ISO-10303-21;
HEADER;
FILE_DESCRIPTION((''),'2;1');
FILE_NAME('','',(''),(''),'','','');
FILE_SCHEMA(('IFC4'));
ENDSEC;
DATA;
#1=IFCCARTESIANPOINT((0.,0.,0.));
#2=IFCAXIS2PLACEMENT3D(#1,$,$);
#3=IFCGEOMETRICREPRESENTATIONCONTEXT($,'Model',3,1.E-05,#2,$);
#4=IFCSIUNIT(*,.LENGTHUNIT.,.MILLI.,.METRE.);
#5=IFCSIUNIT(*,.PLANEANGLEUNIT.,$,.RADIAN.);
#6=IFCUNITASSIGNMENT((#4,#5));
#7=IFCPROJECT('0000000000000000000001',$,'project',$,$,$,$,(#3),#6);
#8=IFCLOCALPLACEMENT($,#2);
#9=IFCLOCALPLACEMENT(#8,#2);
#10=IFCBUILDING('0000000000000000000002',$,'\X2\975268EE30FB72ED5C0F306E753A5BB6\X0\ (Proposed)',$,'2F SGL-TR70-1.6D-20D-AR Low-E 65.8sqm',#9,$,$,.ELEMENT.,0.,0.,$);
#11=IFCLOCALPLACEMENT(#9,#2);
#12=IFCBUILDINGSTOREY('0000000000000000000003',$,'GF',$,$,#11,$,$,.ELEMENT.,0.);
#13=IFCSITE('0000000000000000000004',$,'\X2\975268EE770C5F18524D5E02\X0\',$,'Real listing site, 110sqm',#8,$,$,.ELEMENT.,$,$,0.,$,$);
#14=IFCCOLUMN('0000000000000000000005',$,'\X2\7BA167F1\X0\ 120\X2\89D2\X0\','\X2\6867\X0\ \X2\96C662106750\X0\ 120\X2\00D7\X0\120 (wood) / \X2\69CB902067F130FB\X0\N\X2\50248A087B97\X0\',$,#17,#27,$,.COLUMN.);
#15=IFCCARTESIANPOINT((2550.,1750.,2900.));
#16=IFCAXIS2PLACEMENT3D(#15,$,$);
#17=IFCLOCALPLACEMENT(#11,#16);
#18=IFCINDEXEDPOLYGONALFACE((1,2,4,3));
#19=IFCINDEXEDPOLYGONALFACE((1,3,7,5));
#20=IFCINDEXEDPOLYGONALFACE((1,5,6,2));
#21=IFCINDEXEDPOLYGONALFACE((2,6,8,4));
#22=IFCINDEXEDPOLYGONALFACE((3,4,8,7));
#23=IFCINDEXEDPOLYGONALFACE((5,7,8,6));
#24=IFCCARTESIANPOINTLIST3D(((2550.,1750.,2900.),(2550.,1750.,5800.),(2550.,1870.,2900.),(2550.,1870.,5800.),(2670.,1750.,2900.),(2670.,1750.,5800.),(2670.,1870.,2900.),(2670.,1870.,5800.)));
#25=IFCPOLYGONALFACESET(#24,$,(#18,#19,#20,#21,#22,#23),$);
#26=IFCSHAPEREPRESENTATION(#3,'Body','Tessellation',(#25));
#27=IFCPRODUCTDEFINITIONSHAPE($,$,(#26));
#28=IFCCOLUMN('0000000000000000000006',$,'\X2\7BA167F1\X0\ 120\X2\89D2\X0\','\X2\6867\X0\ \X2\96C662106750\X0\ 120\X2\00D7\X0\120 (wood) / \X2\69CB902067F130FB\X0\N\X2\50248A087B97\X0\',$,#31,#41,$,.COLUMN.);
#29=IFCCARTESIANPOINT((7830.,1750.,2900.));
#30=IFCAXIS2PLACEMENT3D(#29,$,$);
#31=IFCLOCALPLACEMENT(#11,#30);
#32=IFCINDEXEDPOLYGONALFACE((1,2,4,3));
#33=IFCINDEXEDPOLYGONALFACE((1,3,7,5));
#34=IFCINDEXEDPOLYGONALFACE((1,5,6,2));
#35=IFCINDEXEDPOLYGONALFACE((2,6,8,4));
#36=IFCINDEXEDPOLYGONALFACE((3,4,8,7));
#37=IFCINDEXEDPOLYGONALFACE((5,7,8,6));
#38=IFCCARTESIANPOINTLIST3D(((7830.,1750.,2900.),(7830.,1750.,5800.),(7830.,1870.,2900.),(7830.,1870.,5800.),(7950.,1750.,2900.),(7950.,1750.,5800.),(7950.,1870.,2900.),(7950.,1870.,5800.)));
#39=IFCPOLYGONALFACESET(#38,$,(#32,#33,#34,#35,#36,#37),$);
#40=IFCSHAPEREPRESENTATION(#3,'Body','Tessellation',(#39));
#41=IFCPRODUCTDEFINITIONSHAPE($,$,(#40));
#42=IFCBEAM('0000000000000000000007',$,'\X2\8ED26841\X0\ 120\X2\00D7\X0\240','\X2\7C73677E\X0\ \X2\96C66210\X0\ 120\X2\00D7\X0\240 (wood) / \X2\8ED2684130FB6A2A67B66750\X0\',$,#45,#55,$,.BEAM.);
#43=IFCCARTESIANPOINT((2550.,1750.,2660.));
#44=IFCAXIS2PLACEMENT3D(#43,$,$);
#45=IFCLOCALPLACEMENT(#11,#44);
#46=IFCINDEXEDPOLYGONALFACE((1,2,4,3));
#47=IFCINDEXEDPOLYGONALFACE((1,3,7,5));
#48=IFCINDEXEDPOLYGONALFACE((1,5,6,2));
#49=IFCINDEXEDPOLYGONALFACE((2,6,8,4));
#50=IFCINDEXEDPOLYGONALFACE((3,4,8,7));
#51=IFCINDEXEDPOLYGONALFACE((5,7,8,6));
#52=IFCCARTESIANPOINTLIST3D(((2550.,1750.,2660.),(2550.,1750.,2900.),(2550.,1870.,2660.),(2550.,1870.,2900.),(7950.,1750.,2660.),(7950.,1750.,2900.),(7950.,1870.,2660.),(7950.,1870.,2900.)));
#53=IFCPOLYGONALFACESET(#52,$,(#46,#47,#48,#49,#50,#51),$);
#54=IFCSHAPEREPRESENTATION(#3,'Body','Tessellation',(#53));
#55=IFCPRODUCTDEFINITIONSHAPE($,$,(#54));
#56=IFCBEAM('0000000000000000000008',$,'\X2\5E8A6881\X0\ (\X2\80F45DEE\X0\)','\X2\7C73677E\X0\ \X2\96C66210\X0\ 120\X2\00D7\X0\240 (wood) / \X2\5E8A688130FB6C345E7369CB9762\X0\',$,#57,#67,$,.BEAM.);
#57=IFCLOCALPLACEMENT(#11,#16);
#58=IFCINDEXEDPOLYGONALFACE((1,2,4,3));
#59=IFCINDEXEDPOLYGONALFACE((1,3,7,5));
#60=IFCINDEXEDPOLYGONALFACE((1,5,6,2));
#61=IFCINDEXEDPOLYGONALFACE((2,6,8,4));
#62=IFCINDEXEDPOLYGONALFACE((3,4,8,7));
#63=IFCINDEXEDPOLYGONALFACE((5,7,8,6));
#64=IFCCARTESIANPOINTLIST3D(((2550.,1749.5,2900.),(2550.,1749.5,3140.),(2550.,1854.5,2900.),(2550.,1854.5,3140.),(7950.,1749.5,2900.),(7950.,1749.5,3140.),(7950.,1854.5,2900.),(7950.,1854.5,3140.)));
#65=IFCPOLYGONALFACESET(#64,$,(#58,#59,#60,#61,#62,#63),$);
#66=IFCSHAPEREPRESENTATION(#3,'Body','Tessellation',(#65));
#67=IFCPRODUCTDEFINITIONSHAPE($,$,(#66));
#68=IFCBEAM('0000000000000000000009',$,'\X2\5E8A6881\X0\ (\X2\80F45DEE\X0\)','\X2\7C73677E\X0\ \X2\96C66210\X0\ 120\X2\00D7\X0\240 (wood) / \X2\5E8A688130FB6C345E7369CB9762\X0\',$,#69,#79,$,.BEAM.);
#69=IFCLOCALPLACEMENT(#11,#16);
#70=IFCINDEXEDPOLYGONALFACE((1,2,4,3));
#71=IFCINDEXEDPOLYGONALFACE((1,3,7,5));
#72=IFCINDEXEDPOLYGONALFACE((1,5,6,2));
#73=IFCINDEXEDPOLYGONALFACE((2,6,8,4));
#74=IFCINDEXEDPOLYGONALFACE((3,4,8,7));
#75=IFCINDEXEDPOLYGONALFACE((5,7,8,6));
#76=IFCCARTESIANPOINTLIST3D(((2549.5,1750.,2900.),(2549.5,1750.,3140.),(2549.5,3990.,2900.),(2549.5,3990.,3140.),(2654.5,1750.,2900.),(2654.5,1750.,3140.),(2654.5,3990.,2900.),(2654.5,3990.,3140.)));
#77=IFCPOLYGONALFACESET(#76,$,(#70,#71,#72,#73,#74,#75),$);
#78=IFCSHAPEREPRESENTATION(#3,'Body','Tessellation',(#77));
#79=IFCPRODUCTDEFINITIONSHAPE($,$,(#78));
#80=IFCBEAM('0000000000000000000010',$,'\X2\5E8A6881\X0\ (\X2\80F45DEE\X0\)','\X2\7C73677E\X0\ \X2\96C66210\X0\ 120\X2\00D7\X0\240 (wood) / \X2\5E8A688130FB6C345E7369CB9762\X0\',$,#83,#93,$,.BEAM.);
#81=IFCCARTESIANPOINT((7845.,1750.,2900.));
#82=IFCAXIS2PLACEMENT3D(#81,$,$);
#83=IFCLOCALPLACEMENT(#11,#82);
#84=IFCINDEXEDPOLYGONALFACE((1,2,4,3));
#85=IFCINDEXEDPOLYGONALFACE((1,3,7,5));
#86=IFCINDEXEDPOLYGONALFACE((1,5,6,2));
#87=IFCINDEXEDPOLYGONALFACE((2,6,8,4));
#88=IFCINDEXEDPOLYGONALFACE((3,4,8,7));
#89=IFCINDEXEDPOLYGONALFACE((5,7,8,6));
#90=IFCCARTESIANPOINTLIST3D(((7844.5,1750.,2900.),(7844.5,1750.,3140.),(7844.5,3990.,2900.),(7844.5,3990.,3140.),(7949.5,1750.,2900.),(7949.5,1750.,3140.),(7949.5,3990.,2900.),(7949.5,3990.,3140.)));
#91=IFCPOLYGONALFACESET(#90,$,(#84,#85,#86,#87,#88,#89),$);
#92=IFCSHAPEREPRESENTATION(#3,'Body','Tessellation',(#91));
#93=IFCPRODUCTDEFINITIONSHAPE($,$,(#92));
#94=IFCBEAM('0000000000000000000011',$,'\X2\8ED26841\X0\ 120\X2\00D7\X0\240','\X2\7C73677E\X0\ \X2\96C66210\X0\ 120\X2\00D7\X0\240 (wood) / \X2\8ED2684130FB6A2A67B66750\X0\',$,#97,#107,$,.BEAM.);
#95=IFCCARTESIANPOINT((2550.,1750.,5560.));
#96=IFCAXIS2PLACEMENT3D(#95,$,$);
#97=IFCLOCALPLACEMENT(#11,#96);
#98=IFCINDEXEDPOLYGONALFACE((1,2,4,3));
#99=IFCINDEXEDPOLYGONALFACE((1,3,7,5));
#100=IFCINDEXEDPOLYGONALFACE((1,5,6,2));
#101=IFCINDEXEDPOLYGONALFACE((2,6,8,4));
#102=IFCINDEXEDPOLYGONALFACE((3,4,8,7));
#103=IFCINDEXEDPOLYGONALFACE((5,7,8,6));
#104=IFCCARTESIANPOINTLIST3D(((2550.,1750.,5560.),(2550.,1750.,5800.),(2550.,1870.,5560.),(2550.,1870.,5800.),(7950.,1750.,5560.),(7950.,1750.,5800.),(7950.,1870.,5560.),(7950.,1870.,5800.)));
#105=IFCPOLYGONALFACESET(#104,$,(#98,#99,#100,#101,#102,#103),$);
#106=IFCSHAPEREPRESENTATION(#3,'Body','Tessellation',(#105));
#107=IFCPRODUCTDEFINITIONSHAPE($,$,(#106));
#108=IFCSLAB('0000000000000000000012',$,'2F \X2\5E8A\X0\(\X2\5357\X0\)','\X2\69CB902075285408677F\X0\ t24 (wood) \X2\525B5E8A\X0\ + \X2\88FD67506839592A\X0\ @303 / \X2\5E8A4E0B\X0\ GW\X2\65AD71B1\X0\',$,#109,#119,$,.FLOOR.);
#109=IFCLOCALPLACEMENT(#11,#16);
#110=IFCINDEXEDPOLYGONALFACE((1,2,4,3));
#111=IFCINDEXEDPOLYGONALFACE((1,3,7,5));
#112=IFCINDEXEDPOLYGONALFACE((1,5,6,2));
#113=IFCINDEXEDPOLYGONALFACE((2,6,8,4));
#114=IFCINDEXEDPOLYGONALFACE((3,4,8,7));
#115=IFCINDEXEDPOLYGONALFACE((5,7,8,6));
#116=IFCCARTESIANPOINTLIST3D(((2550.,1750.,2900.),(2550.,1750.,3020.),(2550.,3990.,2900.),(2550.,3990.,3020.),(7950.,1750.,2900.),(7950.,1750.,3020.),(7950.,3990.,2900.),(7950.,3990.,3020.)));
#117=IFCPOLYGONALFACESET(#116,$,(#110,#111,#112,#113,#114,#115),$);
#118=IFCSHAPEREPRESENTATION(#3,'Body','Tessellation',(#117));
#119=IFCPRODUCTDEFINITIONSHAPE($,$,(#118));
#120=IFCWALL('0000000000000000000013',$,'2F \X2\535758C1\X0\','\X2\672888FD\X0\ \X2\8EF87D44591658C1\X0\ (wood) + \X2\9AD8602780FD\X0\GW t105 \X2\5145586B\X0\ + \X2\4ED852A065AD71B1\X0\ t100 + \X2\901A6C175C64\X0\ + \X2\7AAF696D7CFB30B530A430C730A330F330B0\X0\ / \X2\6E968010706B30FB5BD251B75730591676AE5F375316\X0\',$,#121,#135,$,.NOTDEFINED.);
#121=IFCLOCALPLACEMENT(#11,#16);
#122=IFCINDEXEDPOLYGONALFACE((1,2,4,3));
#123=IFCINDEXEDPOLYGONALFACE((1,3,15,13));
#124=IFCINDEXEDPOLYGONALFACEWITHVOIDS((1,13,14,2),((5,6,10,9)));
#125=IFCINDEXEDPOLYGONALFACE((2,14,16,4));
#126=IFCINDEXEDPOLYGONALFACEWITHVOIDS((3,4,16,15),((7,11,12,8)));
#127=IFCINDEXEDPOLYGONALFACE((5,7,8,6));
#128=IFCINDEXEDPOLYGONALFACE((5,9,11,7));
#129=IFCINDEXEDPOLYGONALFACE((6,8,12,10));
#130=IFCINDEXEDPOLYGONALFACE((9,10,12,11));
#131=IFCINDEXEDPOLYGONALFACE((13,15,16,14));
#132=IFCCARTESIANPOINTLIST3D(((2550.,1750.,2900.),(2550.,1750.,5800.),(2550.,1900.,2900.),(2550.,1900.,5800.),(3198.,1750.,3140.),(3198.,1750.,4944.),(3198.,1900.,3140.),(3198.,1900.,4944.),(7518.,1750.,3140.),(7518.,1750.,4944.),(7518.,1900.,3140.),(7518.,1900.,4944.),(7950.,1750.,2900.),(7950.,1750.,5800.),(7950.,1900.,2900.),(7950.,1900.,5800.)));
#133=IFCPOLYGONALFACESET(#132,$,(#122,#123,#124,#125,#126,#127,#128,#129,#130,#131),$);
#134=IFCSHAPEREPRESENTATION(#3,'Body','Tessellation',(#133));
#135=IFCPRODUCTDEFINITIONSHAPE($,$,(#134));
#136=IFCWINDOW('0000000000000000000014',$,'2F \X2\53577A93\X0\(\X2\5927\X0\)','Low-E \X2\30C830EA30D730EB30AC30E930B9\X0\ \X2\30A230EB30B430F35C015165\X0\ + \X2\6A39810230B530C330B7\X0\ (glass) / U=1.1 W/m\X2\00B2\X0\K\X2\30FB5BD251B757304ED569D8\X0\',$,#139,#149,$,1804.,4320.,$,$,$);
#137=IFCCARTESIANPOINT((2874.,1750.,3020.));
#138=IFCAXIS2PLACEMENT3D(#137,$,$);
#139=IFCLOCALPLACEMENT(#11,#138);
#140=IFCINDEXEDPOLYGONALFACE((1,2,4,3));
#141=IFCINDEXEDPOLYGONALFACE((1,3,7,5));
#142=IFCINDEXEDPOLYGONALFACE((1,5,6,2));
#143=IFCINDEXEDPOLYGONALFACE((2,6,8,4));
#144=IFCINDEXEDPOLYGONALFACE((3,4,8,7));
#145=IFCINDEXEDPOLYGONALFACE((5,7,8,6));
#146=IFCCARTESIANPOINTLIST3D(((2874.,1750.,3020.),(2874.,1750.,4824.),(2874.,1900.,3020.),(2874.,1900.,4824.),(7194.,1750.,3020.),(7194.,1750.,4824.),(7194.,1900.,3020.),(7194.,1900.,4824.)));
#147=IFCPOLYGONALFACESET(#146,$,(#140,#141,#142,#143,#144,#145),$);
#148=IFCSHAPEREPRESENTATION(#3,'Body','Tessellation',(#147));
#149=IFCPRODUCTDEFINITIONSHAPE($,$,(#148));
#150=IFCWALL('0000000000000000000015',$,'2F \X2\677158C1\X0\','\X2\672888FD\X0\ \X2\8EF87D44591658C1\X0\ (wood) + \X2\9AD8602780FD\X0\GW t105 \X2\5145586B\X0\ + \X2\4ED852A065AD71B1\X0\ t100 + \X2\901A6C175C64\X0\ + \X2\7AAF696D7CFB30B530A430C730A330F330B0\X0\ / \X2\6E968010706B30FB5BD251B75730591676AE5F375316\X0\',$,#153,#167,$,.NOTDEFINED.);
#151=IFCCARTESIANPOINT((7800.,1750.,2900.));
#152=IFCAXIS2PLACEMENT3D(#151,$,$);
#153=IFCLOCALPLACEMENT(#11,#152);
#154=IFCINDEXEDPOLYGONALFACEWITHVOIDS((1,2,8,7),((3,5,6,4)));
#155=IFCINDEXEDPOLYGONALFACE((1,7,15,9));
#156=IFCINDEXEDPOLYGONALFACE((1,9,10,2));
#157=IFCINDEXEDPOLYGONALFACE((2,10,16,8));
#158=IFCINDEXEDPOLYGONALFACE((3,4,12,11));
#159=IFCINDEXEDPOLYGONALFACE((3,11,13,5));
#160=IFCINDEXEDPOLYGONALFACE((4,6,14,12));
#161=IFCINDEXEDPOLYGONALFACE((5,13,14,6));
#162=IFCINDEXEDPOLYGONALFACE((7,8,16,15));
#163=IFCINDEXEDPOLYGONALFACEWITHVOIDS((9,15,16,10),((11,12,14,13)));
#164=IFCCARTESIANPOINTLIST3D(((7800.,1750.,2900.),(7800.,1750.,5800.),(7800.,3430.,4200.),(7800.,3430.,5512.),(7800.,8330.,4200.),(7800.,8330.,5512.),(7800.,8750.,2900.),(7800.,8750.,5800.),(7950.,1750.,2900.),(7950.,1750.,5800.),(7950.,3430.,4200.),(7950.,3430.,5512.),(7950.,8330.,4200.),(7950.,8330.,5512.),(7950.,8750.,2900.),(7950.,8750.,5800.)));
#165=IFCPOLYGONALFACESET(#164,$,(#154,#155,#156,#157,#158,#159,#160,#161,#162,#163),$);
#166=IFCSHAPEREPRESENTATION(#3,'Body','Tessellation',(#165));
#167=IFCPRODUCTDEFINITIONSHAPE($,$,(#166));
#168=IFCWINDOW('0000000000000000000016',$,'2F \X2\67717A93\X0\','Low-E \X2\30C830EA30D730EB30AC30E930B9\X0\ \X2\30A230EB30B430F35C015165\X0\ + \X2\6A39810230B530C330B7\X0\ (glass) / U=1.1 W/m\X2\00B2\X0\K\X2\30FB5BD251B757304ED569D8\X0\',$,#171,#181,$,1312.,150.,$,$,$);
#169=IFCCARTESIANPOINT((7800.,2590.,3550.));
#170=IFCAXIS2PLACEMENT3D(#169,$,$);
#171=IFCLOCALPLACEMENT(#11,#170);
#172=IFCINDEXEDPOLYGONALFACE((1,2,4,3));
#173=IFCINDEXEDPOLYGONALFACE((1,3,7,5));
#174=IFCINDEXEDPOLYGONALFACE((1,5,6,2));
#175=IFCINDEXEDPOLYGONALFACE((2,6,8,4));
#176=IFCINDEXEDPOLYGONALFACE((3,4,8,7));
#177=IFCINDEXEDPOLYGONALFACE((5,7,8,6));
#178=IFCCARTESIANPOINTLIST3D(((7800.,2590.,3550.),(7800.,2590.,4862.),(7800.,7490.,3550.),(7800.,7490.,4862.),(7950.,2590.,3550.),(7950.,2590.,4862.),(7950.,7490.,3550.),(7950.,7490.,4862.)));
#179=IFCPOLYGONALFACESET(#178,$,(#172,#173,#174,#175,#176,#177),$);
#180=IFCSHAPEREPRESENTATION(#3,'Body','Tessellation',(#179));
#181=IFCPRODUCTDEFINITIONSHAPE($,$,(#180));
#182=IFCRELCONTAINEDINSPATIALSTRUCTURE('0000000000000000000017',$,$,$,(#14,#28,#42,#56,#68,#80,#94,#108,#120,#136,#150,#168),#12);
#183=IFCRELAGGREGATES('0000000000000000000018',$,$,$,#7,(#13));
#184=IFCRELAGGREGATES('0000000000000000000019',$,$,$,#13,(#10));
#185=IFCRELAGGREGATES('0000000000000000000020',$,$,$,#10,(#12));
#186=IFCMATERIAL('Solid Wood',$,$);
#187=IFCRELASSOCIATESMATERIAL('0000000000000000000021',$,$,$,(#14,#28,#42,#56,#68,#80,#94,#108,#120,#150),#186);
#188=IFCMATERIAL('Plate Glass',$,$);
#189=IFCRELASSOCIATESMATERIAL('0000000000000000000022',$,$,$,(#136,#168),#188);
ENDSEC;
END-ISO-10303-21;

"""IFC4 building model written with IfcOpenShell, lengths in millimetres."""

from ifc_helpers import new_model, si_unit, frame, frame_2d, origin, place, context, project, spatial, rectangle, extrude, material, element, fill, save


model = new_model("IFC4")

# Units and contexts
model_context = context("Model", 3, precision=1e-05, world=origin())
ifc_project = project(units=[si_unit("LENGTHUNIT", "METRE", prefix="MILLI"), si_unit("PLANEANGLEUNIT", "RADIAN")], contexts=[model_context])

# Site, building, storey
site_placement = place(None, origin())
site = spatial("IfcSite", under=ifc_project, at=site_placement, Name="青森県弘前市", ObjectType="Real listing site, 110sqm", CompositionType="ELEMENT", RefElevation=0.0)
building_placement = place(site_placement, origin())
building = spatial("IfcBuilding", under=site, at=building_placement, Name="青森・狭小の町家 (Proposed)", ObjectType="2F SGL-TR70-1.6D-20D-AR Low-E 65.8sqm", CompositionType="ELEMENT", ElevationOfRefHeight=0.0, ElevationOfTerrain=0.0)
storey_placement = place(building_placement, origin())
storey = spatial("IfcBuildingStorey", under=building, at=storey_placement, Name="GF", CompositionType="ELEMENT", Elevation=0.0)

# Columns
ifc_material_1 = material(Name="Solid Wood")
column_1_placement = place(storey_placement, frame((2550.0, 1750.0, 2900.0)))
element("IfcColumn", 1, at=column_1_placement, inside=storey, material=ifc_material_1, Name="管柱 120角", Description="桧 集成材 120×120 (wood) / 構造柱・N値計算", PredefinedType="COLUMN", context=model_context, shape_type="SweptSolid", body=[
    extrude(rectangle(XDim=120.0, YDim=120.0, at=frame_2d((60.0, 60.0))), frame((2550.0, 1750.0, 2900.0)), (0.0, 0.0, 1.0), 2900.0),
])
column_2_placement = place(storey_placement, frame((7830.0, 1750.0, 2900.0)))
element("IfcColumn", 2, at=column_2_placement, inside=storey, material=ifc_material_1, Name="管柱 120角", Description="桧 集成材 120×120 (wood) / 構造柱・N値計算", PredefinedType="COLUMN", context=model_context, shape_type="SweptSolid", body=[
    extrude(rectangle(XDim=120.0, YDim=120.0, at=frame_2d((60.0, 60.0))), frame((7830.0, 1750.0, 2900.0)), (0.0, 0.0, 1.0), 2900.0),
])

# Beams
beam_1_placement = place(storey_placement, frame((2550.0, 1750.0, 2660.0)))
element("IfcBeam", 3, at=beam_1_placement, inside=storey, material=ifc_material_1, Name="軒桁 120×240", Description="米松 集成 120×240 (wood) / 軒桁・横架材", PredefinedType="BEAM", context=model_context, shape_type="SweptSolid", body=[
    extrude(rectangle(XDim=5400.0, YDim=120.0, at=frame_2d((2700.0, 60.0))), frame((2550.0, 1750.0, 2660.0)), (0.0, 0.0, 1.0), 240.0),
])
beam_2_placement = place(storey_placement, frame((2550.0, 1750.0, 2900.0)))
element("IfcBeam", 4, at=beam_2_placement, inside=storey, material=ifc_material_1, Name="床梁 (胴差)", Description="米松 集成 120×240 (wood) / 床梁・水平構面", PredefinedType="BEAM", context=model_context, shape_type="SweptSolid", body=[
    extrude(rectangle(XDim=5400.0, YDim=105.0, at=frame_2d((2700.0, 52.0))), frame((2550.0, 1750.0, 2900.0)), (0.0, 0.0, 1.0), 240.0),
])
beam_3_placement = place(storey_placement, frame((2550.0, 1750.0, 2900.0)))
element("IfcBeam", 5, at=beam_3_placement, inside=storey, material=ifc_material_1, Name="床梁 (胴差)", Description="米松 集成 120×240 (wood) / 床梁・水平構面", PredefinedType="BEAM", context=model_context, shape_type="SweptSolid", body=[
    extrude(rectangle(XDim=105.0, YDim=2240.0, at=frame_2d((52.0, 1120.0))), frame((2550.0, 1750.0, 2900.0)), (0.0, 0.0, 1.0), 240.0),
])
beam_4_placement = place(storey_placement, frame((7845.0, 1750.0, 2900.0)))
element("IfcBeam", 6, at=beam_4_placement, inside=storey, material=ifc_material_1, Name="床梁 (胴差)", Description="米松 集成 120×240 (wood) / 床梁・水平構面", PredefinedType="BEAM", context=model_context, shape_type="SweptSolid", body=[
    extrude(rectangle(XDim=105.0, YDim=2240.0, at=frame_2d((52.0, 1120.0))), frame((7845.0, 1750.0, 2900.0)), (0.0, 0.0, 1.0), 240.0),
])
beam_5_placement = place(storey_placement, frame((2550.0, 1750.0, 5560.0)))
element("IfcBeam", 7, at=beam_5_placement, inside=storey, material=ifc_material_1, Name="軒桁 120×240", Description="米松 集成 120×240 (wood) / 軒桁・横架材", PredefinedType="BEAM", context=model_context, shape_type="SweptSolid", body=[
    extrude(rectangle(XDim=5400.0, YDim=120.0, at=frame_2d((2700.0, 60.0))), frame((2550.0, 1750.0, 5560.0)), (0.0, 0.0, 1.0), 240.0),
])

# Slab
slab_placement = place(storey_placement, frame((2550.0, 1750.0, 2900.0)))
element("IfcSlab", 8, at=slab_placement, inside=storey, material=ifc_material_1, Name="2F 床(南)", Description="構造用合板 t24 (wood) 剛床 + 製材根太 @303 / 床下 GW断熱", PredefinedType="FLOOR", context=model_context, shape_type="SweptSolid", body=[
    extrude(rectangle(XDim=5400.0, YDim=2240.0, at=frame_2d((2700.0, 1120.0))), frame((2550.0, 1750.0, 2900.0)), (0.0, 0.0, 1.0), 120.0),
])

# Walls, openings, windows
wall_1_placement = place(storey_placement, frame((2550.0, 1750.0, 2900.0)))
wall_1 = element("IfcWall", 9, at=wall_1_placement, inside=storey, material=ifc_material_1, Name="2F 南壁", Description="木製 軸組外壁 (wood) + 高性能GW t105 充填 + 付加断熱 t100 + 通気層 + 窯業系サイディング / 準耐火・寒冷地外皮強化", PredefinedType="NOTDEFINED", context=model_context, shape_type="SweptSolid", body=[
    extrude(rectangle(XDim=5400.0, YDim=150.0, at=frame_2d((2700.0, 75.0))), frame((2550.0, 1750.0, 2900.0)), (0.0, 0.0, 1.0), 2900.0),
])
opening_1_placement = place(storey_placement, frame((2874.0, 1750.0, 3020.0)))
opening_1 = element("IfcOpeningElement", 10, at=opening_1_placement, cuts=wall_1, PredefinedType="NOTDEFINED", context=model_context, shape_type="SweptSolid", body=[
    extrude(rectangle(XDim=4320.0, YDim=150.0, at=frame_2d((2160.0, 75.0))), frame((2874.0, 1750.0, 3020.0)), (0.0, 0.0, 1.0), 1804.0),
])
ifc_material_2 = material(Name="Plate Glass")
window_1_placement = place(storey_placement, frame((2874.0, 1750.0, 3020.0)))
window_1 = element("IfcWindow", 11, at=window_1_placement, inside=storey, material=ifc_material_2, Name="2F 南窓(大)", Description="Low-E トリプルガラス アルゴン封入 + 樹脂サッシ (glass) / U=1.1 W/m²K・寒冷地仕様", OverallHeight=1804.0, OverallWidth=4320.0, context=model_context, shape_type="SweptSolid", body=[
    extrude(rectangle(XDim=4320.0, YDim=150.0, at=frame_2d((2160.0, 75.0))), frame((2874.0, 1750.0, 3020.0)), (0.0, 0.0, 1.0), 1804.0),
])
fill(opening_1, window_1)
wall_2_placement = place(storey_placement, frame((7800.0, 1750.0, 2900.0)))
wall_2 = element("IfcWall", 12, at=wall_2_placement, inside=storey, material=ifc_material_1, Name="2F 東壁", Description="木製 軸組外壁 (wood) + 高性能GW t105 充填 + 付加断熱 t100 + 通気層 + 窯業系サイディング / 準耐火・寒冷地外皮強化", PredefinedType="NOTDEFINED", context=model_context, shape_type="SweptSolid", body=[
    extrude(rectangle(XDim=150.0, YDim=7000.0, at=frame_2d((75.0, 3500.0))), frame((7800.0, 1750.0, 2900.0)), (0.0, 0.0, 1.0), 2900.0),
])
opening_2_placement = place(storey_placement, frame((7800.0, 2590.0, 3550.0)))
opening_2 = element("IfcOpeningElement", 13, at=opening_2_placement, cuts=wall_2, PredefinedType="NOTDEFINED", context=model_context, shape_type="SweptSolid", body=[
    extrude(rectangle(XDim=150.0, YDim=4900.0, at=frame_2d((75.0, 2450.0))), frame((7800.0, 2590.0, 3550.0)), (0.0, 0.0, 1.0), 1312.0),
])
window_2_placement = place(storey_placement, frame((7800.0, 2590.0, 3550.0)))
window_2 = element("IfcWindow", 14, at=window_2_placement, inside=storey, material=ifc_material_2, Name="2F 東窓", Description="Low-E トリプルガラス アルゴン封入 + 樹脂サッシ (glass) / U=1.1 W/m²K・寒冷地仕様", OverallHeight=1312.0, OverallWidth=150.0, context=model_context, shape_type="SweptSolid", body=[
    extrude(rectangle(XDim=150.0, YDim=4900.0, at=frame_2d((75.0, 2450.0))), frame((7800.0, 2590.0, 3550.0)), (0.0, 0.0, 1.0), 1312.0),
])
fill(opening_2, window_2)

save(model, "model.ifc")
